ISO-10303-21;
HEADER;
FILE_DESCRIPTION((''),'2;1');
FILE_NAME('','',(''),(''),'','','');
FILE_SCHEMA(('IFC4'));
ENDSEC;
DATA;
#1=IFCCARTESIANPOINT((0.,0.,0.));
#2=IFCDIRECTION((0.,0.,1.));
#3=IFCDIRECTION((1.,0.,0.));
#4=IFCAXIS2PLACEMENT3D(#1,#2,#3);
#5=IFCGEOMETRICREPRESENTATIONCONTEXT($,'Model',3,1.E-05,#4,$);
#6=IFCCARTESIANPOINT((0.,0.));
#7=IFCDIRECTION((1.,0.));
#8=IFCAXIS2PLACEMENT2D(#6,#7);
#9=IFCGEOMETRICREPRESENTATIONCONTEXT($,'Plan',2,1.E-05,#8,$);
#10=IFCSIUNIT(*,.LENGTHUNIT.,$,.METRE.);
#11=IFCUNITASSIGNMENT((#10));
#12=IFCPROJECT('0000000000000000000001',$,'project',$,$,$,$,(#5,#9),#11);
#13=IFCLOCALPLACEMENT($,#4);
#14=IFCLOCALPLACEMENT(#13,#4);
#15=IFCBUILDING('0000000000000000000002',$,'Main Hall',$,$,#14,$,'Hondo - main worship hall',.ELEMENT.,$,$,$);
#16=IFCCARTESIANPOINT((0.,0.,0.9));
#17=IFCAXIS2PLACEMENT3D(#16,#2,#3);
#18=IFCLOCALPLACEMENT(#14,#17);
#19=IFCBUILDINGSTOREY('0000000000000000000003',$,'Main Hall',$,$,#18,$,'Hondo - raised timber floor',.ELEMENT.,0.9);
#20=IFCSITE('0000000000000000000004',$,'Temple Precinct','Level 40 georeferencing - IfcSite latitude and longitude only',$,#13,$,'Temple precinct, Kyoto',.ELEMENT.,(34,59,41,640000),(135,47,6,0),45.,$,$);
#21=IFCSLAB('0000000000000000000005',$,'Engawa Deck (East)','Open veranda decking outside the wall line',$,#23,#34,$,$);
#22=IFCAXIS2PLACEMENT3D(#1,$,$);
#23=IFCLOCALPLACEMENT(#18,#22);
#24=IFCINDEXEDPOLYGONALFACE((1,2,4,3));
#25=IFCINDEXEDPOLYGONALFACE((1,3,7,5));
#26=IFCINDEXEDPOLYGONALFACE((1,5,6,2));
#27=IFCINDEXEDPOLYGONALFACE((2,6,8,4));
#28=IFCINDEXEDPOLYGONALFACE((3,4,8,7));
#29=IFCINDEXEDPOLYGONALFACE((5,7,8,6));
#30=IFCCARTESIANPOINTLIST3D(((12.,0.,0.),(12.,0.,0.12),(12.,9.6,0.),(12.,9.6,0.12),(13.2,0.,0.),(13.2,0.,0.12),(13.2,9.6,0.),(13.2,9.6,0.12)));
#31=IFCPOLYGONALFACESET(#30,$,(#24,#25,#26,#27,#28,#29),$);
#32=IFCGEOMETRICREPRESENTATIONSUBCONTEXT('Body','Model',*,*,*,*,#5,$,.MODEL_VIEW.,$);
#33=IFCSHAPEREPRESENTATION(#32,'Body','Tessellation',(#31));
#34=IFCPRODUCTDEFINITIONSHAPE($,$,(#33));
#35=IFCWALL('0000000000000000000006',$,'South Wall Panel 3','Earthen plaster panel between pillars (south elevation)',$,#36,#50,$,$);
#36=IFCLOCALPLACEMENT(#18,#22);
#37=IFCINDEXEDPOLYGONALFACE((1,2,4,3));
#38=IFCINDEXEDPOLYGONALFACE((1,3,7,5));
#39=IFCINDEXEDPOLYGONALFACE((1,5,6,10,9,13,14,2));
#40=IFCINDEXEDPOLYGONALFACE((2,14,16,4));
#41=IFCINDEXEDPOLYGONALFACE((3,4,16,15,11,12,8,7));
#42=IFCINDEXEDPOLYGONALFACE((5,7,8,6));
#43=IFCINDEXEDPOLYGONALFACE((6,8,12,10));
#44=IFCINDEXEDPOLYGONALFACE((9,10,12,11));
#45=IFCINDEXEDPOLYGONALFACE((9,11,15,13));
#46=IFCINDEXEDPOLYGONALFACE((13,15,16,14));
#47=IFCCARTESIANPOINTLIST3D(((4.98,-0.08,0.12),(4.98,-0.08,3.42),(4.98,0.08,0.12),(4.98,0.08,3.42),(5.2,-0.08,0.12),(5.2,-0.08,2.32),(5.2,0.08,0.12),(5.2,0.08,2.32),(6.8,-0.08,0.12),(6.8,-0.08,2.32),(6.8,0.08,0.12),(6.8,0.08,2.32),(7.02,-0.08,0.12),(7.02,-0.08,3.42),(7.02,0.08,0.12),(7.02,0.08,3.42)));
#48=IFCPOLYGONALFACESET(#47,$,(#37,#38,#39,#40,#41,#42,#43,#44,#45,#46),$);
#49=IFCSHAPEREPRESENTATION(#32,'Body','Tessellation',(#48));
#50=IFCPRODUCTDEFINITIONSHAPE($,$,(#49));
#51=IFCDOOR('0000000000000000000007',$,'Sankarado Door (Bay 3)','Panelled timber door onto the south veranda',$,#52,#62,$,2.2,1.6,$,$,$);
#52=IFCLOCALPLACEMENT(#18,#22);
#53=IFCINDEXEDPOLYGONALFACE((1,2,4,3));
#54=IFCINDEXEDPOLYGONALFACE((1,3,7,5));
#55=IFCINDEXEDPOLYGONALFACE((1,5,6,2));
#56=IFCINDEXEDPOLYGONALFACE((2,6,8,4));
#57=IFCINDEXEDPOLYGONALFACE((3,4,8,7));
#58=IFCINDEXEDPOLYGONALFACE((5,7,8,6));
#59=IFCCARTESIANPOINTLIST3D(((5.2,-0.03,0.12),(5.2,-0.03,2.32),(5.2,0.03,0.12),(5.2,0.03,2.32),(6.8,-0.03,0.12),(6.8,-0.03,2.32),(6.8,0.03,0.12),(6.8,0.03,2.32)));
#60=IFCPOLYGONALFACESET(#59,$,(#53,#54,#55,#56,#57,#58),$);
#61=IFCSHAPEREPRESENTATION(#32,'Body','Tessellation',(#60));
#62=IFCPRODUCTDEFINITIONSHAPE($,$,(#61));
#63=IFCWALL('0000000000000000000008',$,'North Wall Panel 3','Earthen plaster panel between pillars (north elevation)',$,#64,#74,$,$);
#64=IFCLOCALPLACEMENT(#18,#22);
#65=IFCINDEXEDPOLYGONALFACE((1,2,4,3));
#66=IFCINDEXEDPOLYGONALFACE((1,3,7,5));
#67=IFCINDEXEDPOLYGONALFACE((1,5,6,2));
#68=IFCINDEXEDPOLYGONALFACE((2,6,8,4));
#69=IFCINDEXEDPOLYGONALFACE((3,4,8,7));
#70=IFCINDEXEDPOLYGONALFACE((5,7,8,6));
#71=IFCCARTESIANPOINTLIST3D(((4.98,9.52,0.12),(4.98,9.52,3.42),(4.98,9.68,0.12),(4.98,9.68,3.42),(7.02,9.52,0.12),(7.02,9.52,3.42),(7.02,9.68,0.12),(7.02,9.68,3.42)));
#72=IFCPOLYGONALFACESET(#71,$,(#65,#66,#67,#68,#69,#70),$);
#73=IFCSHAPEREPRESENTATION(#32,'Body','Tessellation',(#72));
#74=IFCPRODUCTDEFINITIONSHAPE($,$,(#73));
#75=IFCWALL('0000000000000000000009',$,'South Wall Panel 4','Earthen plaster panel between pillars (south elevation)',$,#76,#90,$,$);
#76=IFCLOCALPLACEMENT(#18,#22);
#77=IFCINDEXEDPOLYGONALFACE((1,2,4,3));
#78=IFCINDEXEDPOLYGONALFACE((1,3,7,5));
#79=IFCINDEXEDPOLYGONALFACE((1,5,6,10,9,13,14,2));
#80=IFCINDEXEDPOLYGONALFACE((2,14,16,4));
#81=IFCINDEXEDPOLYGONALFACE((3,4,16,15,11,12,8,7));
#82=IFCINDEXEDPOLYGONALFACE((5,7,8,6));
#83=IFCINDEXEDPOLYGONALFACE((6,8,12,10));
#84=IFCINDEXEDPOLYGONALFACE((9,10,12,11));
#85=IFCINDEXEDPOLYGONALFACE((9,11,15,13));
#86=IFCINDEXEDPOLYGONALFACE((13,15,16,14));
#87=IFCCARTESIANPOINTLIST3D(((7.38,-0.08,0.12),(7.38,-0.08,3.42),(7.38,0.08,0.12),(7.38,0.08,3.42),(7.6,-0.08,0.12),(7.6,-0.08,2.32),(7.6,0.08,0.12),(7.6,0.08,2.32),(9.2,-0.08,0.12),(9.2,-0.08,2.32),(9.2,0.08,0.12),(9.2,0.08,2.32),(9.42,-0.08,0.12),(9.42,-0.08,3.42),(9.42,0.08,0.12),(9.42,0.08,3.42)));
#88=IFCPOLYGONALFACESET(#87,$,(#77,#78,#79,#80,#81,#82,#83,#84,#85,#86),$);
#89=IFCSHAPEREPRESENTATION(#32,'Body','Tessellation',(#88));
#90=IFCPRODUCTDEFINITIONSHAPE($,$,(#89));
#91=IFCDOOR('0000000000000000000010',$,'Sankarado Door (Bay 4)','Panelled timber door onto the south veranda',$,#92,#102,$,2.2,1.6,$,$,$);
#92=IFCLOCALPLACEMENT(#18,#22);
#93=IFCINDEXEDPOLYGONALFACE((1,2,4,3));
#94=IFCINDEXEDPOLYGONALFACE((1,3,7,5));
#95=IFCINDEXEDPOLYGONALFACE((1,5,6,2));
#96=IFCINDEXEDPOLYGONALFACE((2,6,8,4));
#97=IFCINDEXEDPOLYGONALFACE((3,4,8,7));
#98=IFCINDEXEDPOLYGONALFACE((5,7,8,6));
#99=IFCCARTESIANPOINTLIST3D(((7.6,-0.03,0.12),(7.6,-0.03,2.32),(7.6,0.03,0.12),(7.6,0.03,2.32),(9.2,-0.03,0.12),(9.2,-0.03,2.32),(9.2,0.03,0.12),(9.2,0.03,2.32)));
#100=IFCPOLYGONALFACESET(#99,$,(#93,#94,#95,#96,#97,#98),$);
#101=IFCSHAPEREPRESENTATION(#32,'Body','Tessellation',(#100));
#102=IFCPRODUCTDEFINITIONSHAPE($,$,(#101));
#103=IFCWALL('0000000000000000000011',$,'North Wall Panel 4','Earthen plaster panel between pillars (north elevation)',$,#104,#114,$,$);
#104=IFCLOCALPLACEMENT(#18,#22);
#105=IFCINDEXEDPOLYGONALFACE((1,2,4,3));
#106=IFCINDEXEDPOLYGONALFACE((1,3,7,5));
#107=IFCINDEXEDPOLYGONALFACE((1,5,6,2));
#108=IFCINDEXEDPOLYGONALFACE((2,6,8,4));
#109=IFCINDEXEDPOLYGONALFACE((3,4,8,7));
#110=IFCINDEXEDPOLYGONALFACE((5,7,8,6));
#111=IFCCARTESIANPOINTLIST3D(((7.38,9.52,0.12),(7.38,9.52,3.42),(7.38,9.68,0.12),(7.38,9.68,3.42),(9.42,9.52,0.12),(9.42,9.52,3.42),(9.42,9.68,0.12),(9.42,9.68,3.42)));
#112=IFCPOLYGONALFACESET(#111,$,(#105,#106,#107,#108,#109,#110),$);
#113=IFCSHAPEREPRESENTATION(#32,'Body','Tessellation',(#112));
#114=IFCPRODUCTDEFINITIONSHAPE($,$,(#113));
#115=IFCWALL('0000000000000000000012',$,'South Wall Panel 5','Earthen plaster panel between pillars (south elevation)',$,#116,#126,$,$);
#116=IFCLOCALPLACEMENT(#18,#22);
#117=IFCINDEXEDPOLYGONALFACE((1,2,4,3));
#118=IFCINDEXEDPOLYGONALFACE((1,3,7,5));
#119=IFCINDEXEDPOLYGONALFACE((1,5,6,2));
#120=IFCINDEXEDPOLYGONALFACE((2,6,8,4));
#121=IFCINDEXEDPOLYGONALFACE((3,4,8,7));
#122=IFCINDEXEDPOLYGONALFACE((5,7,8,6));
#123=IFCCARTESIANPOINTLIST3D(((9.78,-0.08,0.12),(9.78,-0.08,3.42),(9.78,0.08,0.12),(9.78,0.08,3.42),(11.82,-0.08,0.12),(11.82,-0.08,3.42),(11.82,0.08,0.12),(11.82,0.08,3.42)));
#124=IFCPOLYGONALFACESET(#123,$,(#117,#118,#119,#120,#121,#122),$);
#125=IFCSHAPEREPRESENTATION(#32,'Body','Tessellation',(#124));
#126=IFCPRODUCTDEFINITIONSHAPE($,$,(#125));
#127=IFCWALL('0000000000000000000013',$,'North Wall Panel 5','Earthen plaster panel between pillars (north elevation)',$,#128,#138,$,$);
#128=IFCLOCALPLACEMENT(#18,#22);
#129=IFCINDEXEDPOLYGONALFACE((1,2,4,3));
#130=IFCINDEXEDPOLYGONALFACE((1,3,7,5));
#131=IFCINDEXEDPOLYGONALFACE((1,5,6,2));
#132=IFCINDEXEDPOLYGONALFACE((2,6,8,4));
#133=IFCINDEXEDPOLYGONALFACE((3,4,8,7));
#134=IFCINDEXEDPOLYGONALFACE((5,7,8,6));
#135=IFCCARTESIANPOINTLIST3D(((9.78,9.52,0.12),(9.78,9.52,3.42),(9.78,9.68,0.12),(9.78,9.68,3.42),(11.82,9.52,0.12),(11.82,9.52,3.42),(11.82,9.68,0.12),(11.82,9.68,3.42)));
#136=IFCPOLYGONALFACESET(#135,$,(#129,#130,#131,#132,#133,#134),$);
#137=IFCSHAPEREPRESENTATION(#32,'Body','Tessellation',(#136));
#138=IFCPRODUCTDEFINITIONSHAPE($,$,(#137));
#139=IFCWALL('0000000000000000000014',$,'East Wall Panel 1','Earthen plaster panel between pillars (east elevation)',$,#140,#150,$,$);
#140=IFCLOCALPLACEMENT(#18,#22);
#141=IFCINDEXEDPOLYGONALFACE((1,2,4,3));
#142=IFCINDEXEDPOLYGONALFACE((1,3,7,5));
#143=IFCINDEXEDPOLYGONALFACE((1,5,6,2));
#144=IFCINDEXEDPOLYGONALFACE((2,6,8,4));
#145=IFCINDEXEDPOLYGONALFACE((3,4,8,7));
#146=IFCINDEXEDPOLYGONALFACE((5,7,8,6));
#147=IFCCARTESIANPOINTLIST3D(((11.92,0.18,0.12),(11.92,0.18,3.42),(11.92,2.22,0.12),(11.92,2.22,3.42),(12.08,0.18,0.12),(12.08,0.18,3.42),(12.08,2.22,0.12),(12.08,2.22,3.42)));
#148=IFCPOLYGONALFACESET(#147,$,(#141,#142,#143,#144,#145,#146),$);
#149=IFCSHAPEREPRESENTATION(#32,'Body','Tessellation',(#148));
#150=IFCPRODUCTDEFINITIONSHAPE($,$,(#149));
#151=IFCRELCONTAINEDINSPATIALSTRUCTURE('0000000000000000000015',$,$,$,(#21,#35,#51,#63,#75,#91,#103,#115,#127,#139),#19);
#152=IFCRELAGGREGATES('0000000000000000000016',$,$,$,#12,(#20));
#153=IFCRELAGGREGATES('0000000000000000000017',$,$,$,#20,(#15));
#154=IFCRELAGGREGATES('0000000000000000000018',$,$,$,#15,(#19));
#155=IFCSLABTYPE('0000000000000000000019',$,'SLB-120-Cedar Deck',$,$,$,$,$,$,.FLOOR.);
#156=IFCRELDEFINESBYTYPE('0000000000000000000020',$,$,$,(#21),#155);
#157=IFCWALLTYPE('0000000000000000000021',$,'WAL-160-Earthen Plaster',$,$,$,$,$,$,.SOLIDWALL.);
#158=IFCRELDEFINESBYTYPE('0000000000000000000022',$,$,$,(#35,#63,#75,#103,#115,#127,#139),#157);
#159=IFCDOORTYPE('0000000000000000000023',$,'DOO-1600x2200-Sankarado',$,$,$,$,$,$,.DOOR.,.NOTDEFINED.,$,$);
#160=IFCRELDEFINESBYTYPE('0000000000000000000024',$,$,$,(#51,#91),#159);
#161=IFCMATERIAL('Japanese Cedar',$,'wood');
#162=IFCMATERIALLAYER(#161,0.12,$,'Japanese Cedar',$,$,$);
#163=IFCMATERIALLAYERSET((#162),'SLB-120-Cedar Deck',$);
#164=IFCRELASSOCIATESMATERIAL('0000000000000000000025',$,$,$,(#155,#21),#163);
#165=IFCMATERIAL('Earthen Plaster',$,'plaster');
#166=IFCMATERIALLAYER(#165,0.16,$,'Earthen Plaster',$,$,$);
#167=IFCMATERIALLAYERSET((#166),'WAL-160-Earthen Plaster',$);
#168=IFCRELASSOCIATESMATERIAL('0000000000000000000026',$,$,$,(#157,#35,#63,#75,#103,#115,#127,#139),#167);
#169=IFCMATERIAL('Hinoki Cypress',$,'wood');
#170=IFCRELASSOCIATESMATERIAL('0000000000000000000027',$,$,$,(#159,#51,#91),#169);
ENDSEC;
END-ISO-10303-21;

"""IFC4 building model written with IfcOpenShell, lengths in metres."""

from ifc_helpers import new_model, si_unit, frame, origin_with_axes, origin_2d_with_axis, place, context, subcontext, project, spatial, line, indexed_curve, outline, extrude, material, layer, layer_set, layer_usage, type_object, element, fill, save


model = new_model("IFC4")

# Units and contexts
model_context = context("Model", 3, precision=1e-05, world=origin_with_axes())
plan_context = context("Plan", 2, precision=1e-05, world=origin_2d_with_axis())
body_context = subcontext(model_context, "Body", "Model", "MODEL_VIEW")
ifc_project = project(units=[si_unit("LENGTHUNIT", "METRE")], contexts=[model_context, plan_context])

# Site, building, storey
site_placement = place(None, origin_with_axes())
site = spatial("IfcSite", under=ifc_project, at=site_placement, Name="Temple Precinct", Description="Level 40 georeferencing - IfcSite latitude and longitude only", LongName="Temple precinct, Kyoto", CompositionType="ELEMENT", RefLatitude=(34, 59, 41, 640000), RefLongitude=(135, 47, 6, 0), RefElevation=45.0)
building_placement = place(site_placement, origin_with_axes())
building = spatial("IfcBuilding", under=site, at=building_placement, Name="Main Hall", LongName="Hondo - main worship hall", CompositionType="ELEMENT")
storey_placement = place(building_placement, frame((0.0, 0.0, 0.9), z_axis=(0.0, 0.0, 1.0), x_axis=(1.0, 0.0, 0.0)))
storey = spatial("IfcBuildingStorey", under=building, at=storey_placement, Name="Main Hall", LongName="Hondo - raised timber floor", CompositionType="ELEMENT", Elevation=0.9)

# Shared definitions
ifc_material_1 = material(Name="Hinoki Cypress", Category="wood")

# Slab
ifc_material_2 = material(Name="Japanese Cedar", Category="wood")
ifc_layer_1 = layer(ifc_material_2, 0.12, Name="Japanese Cedar")
ifc_layer_set_1 = layer_set([ifc_layer_1], Name="SLB-120-Cedar Deck")
ifc_layer_usage_1 = layer_usage(ifc_layer_set_1, "AXIS3", "POSITIVE", 0.0)
slab_type = type_object("IfcSlabType", Name="SLB-120-Cedar Deck", PredefinedType="FLOOR", material=ifc_layer_set_1)
slab_placement = place(storey_placement, frame((12.0, 0.0, 0.0), z_axis=(0.0, 0.0, 1.0), x_axis=(1.0, 0.0, 0.0)))
element("IfcSlab", 1, at=slab_placement, inside=storey, type_object=slab_type, material=ifc_layer_usage_1, Name="Engawa Deck (East)", Description="Open veranda decking outside the wall line", context=body_context, shape_type="SweptSolid", body=[
    extrude(outline(indexed_curve([(0.0, 0.0), (1.2, 0.0), (1.2, 9.6), (0.0, 9.6)], segments=[line(1, 2, 3, 4, 1)])), origin_with_axes(), (0.0, 0.0, 1.0), 0.12),
])

# Wall, opening, door
ifc_material_3 = material(Name="Earthen Plaster", Category="plaster")
ifc_layer_2 = layer(ifc_material_3, 0.16, Name="Earthen Plaster")
ifc_layer_set_2 = layer_set([ifc_layer_2], Name="WAL-160-Earthen Plaster")
ifc_layer_usage_2 = layer_usage(ifc_layer_set_2, "AXIS2", "POSITIVE", 0.0)
wall_type = type_object("IfcWallType", Name="WAL-160-Earthen Plaster", PredefinedType="SOLIDWALL", material=ifc_layer_set_2)
wall_1_placement = place(storey_placement, frame((4.98, -0.08, 0.12), z_axis=(0.0, 0.0, 1.0), x_axis=(1.0, 0.0, 0.0)))
wall_1 = element("IfcWall", 2, at=wall_1_placement, inside=storey, type_object=wall_type, material=ifc_layer_usage_2, Name="South Wall Panel 3", Description="Earthen plaster panel between pillars (south elevation)", context=body_context, shape_type="SweptSolid", body=[
    extrude(outline(indexed_curve([(0.0, 0.0), (0.0, 0.16), (2.04, 0.16), (2.04, 0.0), (0.0, 0.0)], self_intersect=False)), origin_with_axes(), (0.0, 0.0, 1.0), 3.3),
])
opening_1_placement = place(wall_1_placement, frame((0.22, -0.01, 0.0), z_axis=(0.0, 0.0, 1.0), x_axis=(1.0, 0.0, 0.0)))
opening_1 = element("IfcOpeningElement", 3, at=opening_1_placement, cuts=wall_1, PredefinedType="OPENING", context=body_context, shape_type="SweptSolid", body=[
    extrude(outline(indexed_curve([(0.0, 0.0), (1.6, 0.0), (1.6, 0.18), (0.0, 0.18)], segments=[line(1, 2, 3, 4, 1)])), origin_with_axes(), (0.0, 0.0, 1.0), 2.2),
])
door_type = type_object("IfcDoorType", Name="DOO-1600x2200-Sankarado", OperationType="NOTDEFINED", PredefinedType="DOOR", material=ifc_material_1)
door_1_placement = place(storey_placement, frame((5.2, -0.03, 0.12), z_axis=(0.0, 0.0, 1.0), x_axis=(1.0, 0.0, 0.0)))
door_1 = element("IfcDoor", 4, at=door_1_placement, inside=storey, type_object=door_type, material=ifc_material_1, Name="Sankarado Door (Bay 3)", Description="Panelled timber door onto the south veranda", OverallHeight=2.2, OverallWidth=1.6, context=body_context, shape_type="SweptSolid", body=[
    extrude(outline(indexed_curve([(0.0, 0.0), (1.6, 0.0), (1.6, 0.06), (0.0, 0.06)], segments=[line(1, 2, 3, 4, 1)])), origin_with_axes(), (0.0, 0.0, 1.0), 2.2),
])
fill(opening_1, door_1)

# Wall
ifc_layer_usage_3 = layer_usage(ifc_layer_set_2, "AXIS2", "POSITIVE", 0.0)
wall_2_placement = place(storey_placement, frame((4.98, 9.52, 0.12), z_axis=(0.0, 0.0, 1.0), x_axis=(1.0, 0.0, 0.0)))
element("IfcWall", 5, at=wall_2_placement, inside=storey, type_object=wall_type, material=ifc_layer_usage_3, Name="North Wall Panel 3", Description="Earthen plaster panel between pillars (north elevation)", context=body_context, shape_type="SweptSolid", body=[
    extrude(outline(indexed_curve([(0.0, 0.0), (0.0, 0.16), (2.04, 0.16), (2.04, 0.0), (0.0, 0.0)], self_intersect=False)), origin_with_axes(), (0.0, 0.0, 1.0), 3.3),
])

# Wall, opening, door
ifc_layer_usage_4 = layer_usage(ifc_layer_set_2, "AXIS2", "POSITIVE", 0.0)
wall_3_placement = place(storey_placement, frame((7.38, -0.08, 0.12), z_axis=(0.0, 0.0, 1.0), x_axis=(1.0, 0.0, 0.0)))
wall_3 = element("IfcWall", 6, at=wall_3_placement, inside=storey, type_object=wall_type, material=ifc_layer_usage_4, Name="South Wall Panel 4", Description="Earthen plaster panel between pillars (south elevation)", context=body_context, shape_type="SweptSolid", body=[
    extrude(outline(indexed_curve([(0.0, 0.0), (0.0, 0.16), (2.04, 0.16), (2.04, 0.0), (0.0, 0.0)], self_intersect=False)), origin_with_axes(), (0.0, 0.0, 1.0), 3.3),
])
opening_2_placement = place(wall_3_placement, frame((0.22, -0.01, 0.0), z_axis=(0.0, 0.0, 1.0), x_axis=(1.0, 0.0, 0.0)))
opening_2 = element("IfcOpeningElement", 7, at=opening_2_placement, cuts=wall_3, PredefinedType="OPENING", context=body_context, shape_type="SweptSolid", body=[
    extrude(outline(indexed_curve([(0.0, 0.0), (1.6, 0.0), (1.6, 0.18), (0.0, 0.18)], segments=[line(1, 2, 3, 4, 1)])), origin_with_axes(), (0.0, 0.0, 1.0), 2.2),
])
door_2_placement = place(storey_placement, frame((7.6, -0.03, 0.12), z_axis=(0.0, 0.0, 1.0), x_axis=(1.0, 0.0, 0.0)))
door_2 = element("IfcDoor", 8, at=door_2_placement, inside=storey, type_object=door_type, material=ifc_material_1, Name="Sankarado Door (Bay 4)", Description="Panelled timber door onto the south veranda", OverallHeight=2.2, OverallWidth=1.6, context=body_context, shape_type="SweptSolid", body=[
    extrude(outline(indexed_curve([(0.0, 0.0), (1.6, 0.0), (1.6, 0.06), (0.0, 0.06)], segments=[line(1, 2, 3, 4, 1)])), origin_with_axes(), (0.0, 0.0, 1.0), 2.2),
])
fill(opening_2, door_2)

# Walls
ifc_layer_usage_5 = layer_usage(ifc_layer_set_2, "AXIS2", "POSITIVE", 0.0)
wall_4_placement = place(storey_placement, frame((7.38, 9.52, 0.12), z_axis=(0.0, 0.0, 1.0), x_axis=(1.0, 0.0, 0.0)))
element("IfcWall", 9, at=wall_4_placement, inside=storey, type_object=wall_type, material=ifc_layer_usage_5, Name="North Wall Panel 4", Description="Earthen plaster panel between pillars (north elevation)", context=body_context, shape_type="SweptSolid", body=[
    extrude(outline(indexed_curve([(0.0, 0.0), (0.0, 0.16), (2.04, 0.16), (2.04, 0.0), (0.0, 0.0)], self_intersect=False)), origin_with_axes(), (0.0, 0.0, 1.0), 3.3),
])
ifc_layer_usage_6 = layer_usage(ifc_layer_set_2, "AXIS2", "POSITIVE", 0.0)
wall_5_placement = place(storey_placement, frame((9.78, -0.08, 0.12), z_axis=(0.0, 0.0, 1.0), x_axis=(1.0, 0.0, 0.0)))
element("IfcWall", 10, at=wall_5_placement, inside=storey, type_object=wall_type, material=ifc_layer_usage_6, Name="South Wall Panel 5", Description="Earthen plaster panel between pillars (south elevation)", context=body_context, shape_type="SweptSolid", body=[
    extrude(outline(indexed_curve([(0.0, 0.0), (0.0, 0.16), (2.04, 0.16), (2.04, 0.0), (0.0, 0.0)], self_intersect=False)), origin_with_axes(), (0.0, 0.0, 1.0), 3.3),
])
ifc_layer_usage_7 = layer_usage(ifc_layer_set_2, "AXIS2", "POSITIVE", 0.0)
wall_6_placement = place(storey_placement, frame((9.78, 9.52, 0.12), z_axis=(0.0, 0.0, 1.0), x_axis=(1.0, 0.0, 0.0)))
element("IfcWall", 11, at=wall_6_placement, inside=storey, type_object=wall_type, material=ifc_layer_usage_7, Name="North Wall Panel 5", Description="Earthen plaster panel between pillars (north elevation)", context=body_context, shape_type="SweptSolid", body=[
    extrude(outline(indexed_curve([(0.0, 0.0), (0.0, 0.16), (2.04, 0.16), (2.04, 0.0), (0.0, 0.0)], self_intersect=False)), origin_with_axes(), (0.0, 0.0, 1.0), 3.3),
])
ifc_layer_usage_8 = layer_usage(ifc_layer_set_2, "AXIS2", "POSITIVE", 0.0)
wall_7_placement = place(storey_placement, frame((11.92, 2.22, 0.12), z_axis=(0.0, 0.0, 1.0), x_axis=(0.0, -1.0, 0.0)))
element("IfcWall", 12, at=wall_7_placement, inside=storey, type_object=wall_type, material=ifc_layer_usage_8, Name="East Wall Panel 1", Description="Earthen plaster panel between pillars (east elevation)", context=body_context, shape_type="SweptSolid", body=[
    extrude(outline(indexed_curve([(0.0, 0.0), (0.0, 0.16), (2.04, 0.16), (2.04, 0.0), (0.0, 0.0)], self_intersect=False)), origin_with_axes(), (0.0, 0.0, 1.0), 3.3),
])

save(model, "model.ifc")
